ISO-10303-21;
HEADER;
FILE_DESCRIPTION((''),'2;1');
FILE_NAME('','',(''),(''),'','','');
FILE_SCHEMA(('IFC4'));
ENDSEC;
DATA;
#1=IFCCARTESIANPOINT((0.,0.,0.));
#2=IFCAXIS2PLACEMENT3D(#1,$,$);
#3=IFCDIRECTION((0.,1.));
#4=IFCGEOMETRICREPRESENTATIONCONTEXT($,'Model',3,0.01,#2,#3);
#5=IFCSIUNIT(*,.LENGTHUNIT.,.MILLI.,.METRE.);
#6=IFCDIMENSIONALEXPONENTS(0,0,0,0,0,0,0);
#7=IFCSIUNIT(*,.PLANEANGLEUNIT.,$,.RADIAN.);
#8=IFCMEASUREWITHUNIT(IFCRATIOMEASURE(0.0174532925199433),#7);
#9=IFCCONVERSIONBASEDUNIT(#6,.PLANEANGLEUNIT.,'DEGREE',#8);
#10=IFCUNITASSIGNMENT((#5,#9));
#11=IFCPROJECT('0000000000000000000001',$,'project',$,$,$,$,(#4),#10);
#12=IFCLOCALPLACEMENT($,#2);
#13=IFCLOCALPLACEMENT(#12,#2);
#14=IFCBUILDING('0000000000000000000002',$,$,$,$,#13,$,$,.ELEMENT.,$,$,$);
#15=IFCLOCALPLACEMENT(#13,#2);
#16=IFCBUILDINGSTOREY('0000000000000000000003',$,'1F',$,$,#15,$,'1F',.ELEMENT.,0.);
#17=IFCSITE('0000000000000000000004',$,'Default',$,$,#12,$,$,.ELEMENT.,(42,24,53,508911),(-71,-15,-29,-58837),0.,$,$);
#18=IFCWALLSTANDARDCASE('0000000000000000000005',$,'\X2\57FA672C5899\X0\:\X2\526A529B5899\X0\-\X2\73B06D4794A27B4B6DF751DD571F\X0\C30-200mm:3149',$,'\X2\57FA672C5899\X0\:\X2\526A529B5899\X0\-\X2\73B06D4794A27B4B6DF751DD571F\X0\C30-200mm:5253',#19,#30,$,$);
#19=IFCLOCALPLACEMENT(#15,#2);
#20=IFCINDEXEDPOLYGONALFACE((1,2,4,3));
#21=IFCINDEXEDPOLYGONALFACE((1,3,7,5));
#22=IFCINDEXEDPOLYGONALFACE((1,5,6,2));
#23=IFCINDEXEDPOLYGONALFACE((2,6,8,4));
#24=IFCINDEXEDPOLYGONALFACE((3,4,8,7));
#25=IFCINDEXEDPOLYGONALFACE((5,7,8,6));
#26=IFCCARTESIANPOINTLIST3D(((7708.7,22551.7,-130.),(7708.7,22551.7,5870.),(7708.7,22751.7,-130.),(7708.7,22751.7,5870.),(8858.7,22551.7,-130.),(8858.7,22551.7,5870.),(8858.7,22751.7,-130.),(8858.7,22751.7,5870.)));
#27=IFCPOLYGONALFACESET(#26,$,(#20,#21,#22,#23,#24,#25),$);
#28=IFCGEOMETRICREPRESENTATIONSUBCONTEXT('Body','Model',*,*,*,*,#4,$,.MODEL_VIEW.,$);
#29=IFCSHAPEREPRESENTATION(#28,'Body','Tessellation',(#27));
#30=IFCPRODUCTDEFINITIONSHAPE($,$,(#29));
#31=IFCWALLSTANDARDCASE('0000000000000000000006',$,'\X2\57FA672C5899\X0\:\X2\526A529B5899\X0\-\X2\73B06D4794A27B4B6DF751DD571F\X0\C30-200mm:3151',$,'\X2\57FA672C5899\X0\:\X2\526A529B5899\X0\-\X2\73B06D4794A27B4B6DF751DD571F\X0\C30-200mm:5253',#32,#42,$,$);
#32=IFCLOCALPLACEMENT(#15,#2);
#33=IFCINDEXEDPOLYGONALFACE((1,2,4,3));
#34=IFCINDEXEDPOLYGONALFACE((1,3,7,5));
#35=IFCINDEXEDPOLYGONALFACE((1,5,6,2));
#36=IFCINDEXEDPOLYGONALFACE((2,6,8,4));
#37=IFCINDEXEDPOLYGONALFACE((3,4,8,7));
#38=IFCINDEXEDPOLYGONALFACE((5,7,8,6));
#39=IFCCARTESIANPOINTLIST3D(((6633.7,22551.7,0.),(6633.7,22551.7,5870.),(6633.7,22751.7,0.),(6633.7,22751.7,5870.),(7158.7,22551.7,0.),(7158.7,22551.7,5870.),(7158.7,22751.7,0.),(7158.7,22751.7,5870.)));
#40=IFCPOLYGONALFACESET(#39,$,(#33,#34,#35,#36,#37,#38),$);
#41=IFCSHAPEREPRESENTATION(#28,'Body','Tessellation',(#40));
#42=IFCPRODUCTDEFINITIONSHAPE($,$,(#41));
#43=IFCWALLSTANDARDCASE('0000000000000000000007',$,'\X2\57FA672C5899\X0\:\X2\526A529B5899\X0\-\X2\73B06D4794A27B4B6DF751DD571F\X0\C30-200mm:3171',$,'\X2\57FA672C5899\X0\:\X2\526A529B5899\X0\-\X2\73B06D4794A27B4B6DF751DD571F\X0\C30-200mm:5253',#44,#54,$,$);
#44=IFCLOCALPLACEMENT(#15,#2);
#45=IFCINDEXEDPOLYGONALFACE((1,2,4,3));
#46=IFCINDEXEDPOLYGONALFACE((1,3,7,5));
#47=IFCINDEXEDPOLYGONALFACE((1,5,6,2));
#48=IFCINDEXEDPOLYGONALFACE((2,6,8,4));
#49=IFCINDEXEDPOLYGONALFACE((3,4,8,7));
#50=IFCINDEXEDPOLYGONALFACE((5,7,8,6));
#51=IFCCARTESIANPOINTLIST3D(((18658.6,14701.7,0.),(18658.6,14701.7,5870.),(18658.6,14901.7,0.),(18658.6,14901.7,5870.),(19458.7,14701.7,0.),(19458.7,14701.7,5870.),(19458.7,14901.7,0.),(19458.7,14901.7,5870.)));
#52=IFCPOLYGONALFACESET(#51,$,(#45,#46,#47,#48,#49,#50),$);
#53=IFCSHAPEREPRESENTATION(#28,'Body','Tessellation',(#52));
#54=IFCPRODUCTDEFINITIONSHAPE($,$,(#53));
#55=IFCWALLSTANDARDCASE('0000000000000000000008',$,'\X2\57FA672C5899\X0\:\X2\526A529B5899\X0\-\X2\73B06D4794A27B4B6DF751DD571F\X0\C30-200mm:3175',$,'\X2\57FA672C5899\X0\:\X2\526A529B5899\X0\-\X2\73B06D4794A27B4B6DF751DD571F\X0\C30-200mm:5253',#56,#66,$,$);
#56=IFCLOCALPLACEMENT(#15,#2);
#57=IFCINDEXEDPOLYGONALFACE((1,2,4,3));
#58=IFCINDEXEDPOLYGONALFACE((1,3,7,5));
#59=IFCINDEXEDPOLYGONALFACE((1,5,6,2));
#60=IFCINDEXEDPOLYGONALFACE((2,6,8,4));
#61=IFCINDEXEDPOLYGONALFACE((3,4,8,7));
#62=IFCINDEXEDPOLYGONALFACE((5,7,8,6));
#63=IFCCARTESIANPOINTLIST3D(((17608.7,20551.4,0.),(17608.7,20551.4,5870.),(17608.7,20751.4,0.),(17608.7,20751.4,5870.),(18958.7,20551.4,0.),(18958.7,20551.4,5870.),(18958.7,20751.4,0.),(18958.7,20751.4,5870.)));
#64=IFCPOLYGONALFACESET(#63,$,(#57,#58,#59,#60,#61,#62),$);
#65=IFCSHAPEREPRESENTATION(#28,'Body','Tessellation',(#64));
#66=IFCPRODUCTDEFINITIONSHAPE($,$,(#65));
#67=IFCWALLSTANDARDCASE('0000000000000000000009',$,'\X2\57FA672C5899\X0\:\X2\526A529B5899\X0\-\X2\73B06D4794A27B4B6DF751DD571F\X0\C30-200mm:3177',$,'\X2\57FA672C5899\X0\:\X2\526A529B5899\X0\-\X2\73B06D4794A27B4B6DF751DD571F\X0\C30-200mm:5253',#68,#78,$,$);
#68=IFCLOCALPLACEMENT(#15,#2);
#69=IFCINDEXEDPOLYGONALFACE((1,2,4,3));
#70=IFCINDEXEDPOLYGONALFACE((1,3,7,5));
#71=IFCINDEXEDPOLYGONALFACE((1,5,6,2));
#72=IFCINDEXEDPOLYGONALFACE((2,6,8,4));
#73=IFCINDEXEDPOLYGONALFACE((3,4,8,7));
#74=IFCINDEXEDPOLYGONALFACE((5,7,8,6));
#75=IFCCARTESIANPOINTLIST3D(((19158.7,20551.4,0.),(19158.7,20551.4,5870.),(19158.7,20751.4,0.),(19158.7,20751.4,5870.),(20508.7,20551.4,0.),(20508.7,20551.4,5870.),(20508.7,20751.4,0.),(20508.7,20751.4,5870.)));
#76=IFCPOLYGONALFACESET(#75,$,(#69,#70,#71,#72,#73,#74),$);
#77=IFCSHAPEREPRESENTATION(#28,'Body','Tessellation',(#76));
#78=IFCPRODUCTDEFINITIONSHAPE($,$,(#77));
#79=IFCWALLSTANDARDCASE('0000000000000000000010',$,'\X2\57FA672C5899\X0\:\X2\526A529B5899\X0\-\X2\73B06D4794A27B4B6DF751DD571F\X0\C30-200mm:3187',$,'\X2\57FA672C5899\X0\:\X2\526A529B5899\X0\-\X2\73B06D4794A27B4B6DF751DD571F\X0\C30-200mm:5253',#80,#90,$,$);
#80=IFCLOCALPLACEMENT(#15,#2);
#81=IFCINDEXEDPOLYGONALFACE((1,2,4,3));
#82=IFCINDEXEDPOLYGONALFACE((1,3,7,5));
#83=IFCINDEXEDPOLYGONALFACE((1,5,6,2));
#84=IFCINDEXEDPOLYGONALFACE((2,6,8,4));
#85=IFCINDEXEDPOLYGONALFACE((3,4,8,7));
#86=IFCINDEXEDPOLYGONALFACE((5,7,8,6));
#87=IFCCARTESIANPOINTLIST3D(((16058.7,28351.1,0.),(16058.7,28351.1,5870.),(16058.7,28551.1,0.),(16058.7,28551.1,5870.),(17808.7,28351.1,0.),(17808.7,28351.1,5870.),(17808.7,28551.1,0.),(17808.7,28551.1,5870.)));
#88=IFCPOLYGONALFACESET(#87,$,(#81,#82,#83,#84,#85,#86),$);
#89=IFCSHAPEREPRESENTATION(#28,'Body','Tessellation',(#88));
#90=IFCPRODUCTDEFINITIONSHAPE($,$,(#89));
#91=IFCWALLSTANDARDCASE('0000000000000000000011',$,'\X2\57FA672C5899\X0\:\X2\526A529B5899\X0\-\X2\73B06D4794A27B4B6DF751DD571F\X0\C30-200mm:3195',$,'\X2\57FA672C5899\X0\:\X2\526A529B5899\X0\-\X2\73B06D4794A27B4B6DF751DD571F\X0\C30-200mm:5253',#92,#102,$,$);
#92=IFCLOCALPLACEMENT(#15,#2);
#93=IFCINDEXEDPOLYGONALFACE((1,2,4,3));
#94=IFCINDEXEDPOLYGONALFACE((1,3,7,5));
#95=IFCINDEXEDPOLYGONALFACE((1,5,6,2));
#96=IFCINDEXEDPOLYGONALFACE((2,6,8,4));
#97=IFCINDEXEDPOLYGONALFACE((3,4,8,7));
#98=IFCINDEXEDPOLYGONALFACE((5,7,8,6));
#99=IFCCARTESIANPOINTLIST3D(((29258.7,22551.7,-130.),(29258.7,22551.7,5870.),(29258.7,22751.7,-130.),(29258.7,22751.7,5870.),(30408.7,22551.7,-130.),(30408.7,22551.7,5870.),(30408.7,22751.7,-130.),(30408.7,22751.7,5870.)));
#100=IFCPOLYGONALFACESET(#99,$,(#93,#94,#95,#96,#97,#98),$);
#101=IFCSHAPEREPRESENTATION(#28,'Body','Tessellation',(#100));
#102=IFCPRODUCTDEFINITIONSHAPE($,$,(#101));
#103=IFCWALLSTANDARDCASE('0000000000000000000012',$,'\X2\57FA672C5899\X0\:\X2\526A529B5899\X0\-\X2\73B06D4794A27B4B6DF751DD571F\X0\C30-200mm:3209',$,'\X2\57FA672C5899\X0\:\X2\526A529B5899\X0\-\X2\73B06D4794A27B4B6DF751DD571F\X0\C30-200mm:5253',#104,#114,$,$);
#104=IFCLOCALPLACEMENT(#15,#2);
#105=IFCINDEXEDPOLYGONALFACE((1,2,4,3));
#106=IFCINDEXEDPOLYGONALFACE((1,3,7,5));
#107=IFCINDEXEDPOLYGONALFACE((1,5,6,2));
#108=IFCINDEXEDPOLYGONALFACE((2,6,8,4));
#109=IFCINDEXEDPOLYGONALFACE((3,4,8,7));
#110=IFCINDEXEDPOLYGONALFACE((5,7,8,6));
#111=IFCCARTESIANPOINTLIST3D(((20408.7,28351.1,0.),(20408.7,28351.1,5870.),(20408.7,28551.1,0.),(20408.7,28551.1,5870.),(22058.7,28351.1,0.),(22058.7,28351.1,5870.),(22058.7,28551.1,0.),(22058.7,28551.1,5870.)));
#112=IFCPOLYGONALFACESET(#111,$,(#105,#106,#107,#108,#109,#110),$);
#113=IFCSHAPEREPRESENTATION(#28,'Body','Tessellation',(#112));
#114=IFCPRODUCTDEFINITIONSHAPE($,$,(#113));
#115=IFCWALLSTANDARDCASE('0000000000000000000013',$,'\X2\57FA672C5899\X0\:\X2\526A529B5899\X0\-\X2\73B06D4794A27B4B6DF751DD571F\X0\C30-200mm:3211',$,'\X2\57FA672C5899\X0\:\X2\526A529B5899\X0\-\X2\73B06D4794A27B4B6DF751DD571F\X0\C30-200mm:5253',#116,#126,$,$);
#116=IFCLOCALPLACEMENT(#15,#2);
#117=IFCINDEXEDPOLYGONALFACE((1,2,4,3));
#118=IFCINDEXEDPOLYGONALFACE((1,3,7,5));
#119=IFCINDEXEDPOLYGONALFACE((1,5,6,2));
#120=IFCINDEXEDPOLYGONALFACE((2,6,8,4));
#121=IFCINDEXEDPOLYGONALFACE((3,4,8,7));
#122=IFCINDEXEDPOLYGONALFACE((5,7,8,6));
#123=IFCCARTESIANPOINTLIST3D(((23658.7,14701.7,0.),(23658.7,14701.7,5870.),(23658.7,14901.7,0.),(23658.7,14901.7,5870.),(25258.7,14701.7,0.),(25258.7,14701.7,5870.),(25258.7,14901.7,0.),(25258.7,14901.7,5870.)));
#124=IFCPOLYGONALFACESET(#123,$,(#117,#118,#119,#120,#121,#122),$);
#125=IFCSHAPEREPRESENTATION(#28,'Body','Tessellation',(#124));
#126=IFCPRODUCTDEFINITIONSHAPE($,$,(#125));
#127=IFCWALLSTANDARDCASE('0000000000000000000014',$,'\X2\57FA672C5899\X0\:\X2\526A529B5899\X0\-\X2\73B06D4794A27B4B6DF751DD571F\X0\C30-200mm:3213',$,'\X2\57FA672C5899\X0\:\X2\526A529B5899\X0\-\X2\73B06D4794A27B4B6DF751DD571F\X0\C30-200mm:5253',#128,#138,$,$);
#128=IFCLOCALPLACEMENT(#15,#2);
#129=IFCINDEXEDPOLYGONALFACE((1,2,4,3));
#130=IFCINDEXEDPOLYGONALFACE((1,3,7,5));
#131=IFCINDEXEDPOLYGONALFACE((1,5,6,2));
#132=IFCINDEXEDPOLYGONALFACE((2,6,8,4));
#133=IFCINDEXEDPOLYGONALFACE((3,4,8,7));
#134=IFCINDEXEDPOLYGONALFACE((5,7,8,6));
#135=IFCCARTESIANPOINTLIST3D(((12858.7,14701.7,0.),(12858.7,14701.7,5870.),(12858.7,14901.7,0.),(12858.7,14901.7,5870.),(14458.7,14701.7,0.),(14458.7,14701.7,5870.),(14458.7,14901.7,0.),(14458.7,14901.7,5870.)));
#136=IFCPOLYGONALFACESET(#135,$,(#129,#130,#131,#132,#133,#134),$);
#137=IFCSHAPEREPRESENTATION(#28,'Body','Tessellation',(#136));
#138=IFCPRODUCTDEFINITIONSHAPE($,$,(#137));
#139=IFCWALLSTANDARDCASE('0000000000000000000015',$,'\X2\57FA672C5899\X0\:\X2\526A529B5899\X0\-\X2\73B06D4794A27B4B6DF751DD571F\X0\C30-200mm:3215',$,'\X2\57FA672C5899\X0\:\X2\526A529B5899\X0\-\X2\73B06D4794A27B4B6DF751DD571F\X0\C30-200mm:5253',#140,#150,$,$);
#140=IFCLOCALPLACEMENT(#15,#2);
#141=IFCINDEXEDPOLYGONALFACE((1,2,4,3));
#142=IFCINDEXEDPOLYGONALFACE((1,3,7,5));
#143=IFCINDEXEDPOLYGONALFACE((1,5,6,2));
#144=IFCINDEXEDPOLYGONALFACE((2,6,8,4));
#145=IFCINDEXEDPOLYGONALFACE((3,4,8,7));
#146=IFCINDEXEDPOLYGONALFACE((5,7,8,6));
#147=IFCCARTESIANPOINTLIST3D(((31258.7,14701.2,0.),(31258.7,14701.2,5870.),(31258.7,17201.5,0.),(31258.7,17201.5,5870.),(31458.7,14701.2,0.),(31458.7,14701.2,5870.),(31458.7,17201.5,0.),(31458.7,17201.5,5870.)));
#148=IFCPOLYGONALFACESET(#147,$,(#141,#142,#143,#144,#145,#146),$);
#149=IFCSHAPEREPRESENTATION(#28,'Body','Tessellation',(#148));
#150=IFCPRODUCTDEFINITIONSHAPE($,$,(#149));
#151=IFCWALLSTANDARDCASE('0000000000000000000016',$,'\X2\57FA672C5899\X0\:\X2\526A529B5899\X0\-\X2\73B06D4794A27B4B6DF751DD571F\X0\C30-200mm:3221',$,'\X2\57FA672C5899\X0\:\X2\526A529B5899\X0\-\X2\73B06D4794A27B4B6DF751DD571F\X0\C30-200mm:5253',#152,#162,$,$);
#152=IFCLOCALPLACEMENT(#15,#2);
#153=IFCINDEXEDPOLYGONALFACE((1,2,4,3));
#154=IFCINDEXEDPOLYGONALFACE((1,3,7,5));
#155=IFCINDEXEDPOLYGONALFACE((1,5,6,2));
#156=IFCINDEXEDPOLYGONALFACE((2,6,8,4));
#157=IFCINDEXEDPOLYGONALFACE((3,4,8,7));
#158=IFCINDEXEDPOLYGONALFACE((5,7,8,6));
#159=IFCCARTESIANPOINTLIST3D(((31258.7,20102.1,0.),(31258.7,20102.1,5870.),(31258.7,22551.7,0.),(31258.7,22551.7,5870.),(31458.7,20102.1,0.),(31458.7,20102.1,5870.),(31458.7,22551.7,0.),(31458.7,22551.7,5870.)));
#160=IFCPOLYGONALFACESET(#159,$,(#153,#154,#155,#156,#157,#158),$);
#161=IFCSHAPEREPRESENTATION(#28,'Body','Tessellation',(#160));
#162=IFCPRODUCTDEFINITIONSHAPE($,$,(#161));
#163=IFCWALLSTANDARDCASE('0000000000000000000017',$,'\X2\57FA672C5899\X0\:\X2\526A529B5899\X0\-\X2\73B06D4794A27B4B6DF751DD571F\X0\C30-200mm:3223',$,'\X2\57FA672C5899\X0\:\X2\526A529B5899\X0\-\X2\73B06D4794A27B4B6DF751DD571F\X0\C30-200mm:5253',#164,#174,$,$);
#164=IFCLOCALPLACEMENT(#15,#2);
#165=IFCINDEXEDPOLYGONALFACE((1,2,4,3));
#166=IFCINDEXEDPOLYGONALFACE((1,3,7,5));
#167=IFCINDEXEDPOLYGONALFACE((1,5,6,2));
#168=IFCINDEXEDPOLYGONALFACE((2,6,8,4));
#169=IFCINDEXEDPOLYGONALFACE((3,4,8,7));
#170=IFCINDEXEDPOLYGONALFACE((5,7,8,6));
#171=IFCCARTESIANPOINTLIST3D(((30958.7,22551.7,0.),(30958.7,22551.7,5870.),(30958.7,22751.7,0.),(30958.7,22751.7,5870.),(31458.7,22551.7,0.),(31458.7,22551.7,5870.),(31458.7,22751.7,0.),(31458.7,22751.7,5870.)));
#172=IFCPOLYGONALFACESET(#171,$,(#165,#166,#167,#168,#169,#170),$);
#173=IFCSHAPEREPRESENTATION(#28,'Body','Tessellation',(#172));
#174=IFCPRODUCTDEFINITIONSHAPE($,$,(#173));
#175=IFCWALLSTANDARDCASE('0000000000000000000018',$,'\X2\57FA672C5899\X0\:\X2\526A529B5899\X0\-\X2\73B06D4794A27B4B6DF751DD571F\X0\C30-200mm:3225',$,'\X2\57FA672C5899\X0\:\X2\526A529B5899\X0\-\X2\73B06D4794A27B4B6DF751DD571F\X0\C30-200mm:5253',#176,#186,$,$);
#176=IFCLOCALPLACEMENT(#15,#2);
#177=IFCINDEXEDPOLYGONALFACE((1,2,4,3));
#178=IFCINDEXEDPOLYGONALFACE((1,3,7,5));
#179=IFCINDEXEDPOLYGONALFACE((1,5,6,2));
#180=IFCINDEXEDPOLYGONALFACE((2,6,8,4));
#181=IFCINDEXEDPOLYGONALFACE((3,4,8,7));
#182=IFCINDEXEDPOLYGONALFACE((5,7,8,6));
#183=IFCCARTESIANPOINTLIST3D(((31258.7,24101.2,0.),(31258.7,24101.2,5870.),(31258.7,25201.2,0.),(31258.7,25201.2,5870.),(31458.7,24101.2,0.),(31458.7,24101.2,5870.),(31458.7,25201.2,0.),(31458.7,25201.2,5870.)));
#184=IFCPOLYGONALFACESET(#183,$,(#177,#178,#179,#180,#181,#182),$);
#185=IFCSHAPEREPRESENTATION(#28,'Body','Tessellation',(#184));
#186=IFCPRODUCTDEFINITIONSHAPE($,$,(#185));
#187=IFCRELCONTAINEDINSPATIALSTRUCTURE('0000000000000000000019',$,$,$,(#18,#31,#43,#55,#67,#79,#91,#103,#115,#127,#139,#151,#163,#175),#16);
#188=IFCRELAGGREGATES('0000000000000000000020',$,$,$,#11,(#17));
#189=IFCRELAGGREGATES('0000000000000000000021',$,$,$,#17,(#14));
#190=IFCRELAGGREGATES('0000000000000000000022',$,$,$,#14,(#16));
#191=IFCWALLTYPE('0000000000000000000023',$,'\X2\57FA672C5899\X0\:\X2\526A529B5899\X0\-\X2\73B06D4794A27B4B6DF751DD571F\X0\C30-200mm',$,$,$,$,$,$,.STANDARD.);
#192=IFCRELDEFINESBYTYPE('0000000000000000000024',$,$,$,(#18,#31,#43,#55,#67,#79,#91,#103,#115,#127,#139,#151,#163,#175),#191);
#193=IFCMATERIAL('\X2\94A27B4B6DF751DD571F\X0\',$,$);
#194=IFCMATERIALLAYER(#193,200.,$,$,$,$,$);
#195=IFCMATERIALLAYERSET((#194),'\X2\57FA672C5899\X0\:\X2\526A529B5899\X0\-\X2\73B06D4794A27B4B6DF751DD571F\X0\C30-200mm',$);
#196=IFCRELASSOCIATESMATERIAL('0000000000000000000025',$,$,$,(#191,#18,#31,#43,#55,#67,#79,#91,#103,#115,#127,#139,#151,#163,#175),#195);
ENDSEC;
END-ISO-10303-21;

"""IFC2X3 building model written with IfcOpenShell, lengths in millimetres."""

from ifc_helpers import new_model, entity, si_unit, converted_unit, direction, frame, frame_2d, origin, place, context, subcontext, project, spatial, rectangle, extrude, material, layer, layer_set, layer_usage, type_object, element, save


model = new_model("IFC2X3")

# Units and contexts
model_context = context("Model", 3, precision=0.01, world=origin(), true_north=direction((0.0, 1.0)))
body_context = subcontext(model_context, "Body", "Model", "MODEL_VIEW")
ifc_project = project(units=[si_unit("LENGTHUNIT", "METRE", prefix="MILLI"), converted_unit("PLANEANGLEUNIT", "DEGREE", entity("IfcRatioMeasure", 0.0174532925199433), si_unit("PLANEANGLEUNIT", "RADIAN"), dimensions=[0, 0, 0, 0, 0, 0, 0])], contexts=[model_context])

# Site, building, storey
site_placement = place(None, origin())
site = spatial("IfcSite", under=ifc_project, at=site_placement, Name="Default", CompositionType="ELEMENT", RefLatitude=(42, 24, 53, 508911), RefLongitude=(-71, -15, -29, -58837), RefElevation=0.0)
building_placement = place(site_placement, origin())
building = spatial("IfcBuilding", under=site, at=building_placement, CompositionType="ELEMENT")
storey_placement = place(building_placement, origin())
storey = spatial("IfcBuildingStorey", under=building, at=storey_placement, Name="1F", LongName="1F", CompositionType="ELEMENT", Elevation=0.0)

# Walls
ifc_material = material(Name="钢筋混凝土")
ifc_layer_1 = layer(ifc_material, 200.0)
ifc_layer_set_1 = layer_set([ifc_layer_1], Name="基本墙:剪力墙-现浇钢筋混凝土C30-200mm")
ifc_layer_usage_1 = layer_usage(ifc_layer_set_1, "AXIS2", "NEGATIVE", 100.0)
wall_type_1 = type_object("IfcWallType", Name="基本墙:剪力墙-现浇钢筋混凝土C30-200mm", PredefinedType="STANDARD", material=ifc_layer_set_1)
wall_1_placement = place(storey_placement, frame((7708.7, 22651.7, -130.0)))
element("IfcWallStandardCase", 1, at=wall_1_placement, inside=storey, type_object=wall_type_1, material=ifc_layer_usage_1, Name="基本墙:剪力墙-现浇钢筋混凝土C30-200mm:3149", ObjectType="基本墙:剪力墙-现浇钢筋混凝土C30-200mm:5253", context=body_context, shape_type="SweptSolid", body=[
    extrude(rectangle(XDim=1150.0, YDim=200.0, at=frame_2d((575.0, 0.0), x_axis=(-1.0, 0.0))), origin(), (0.0, 0.0, 1.0), 6000.0),
])
ifc_layer_usage_2 = layer_usage(ifc_layer_set_1, "AXIS2", "NEGATIVE", 100.0)
wall_2_placement = place(storey_placement, frame((7158.7, 22651.7, 0.0), z_axis=(0.0, 0.0, 1.0), x_axis=(-1.0, 0.0, 0.0)))
element("IfcWallStandardCase", 2, at=wall_2_placement, inside=storey, type_object=wall_type_1, material=ifc_layer_usage_2, Name="基本墙:剪力墙-现浇钢筋混凝土C30-200mm:3151", ObjectType="基本墙:剪力墙-现浇钢筋混凝土C30-200mm:5253", context=body_context, shape_type="SweptSolid", body=[
    extrude(rectangle(XDim=525.0, YDim=200.0, at=frame_2d((262.5, 0.0), x_axis=(-1.0, 0.0))), origin(), (0.0, 0.0, 1.0), 5870.0),
])
ifc_layer_usage_3 = layer_usage(ifc_layer_set_1, "AXIS2", "NEGATIVE", 100.0)
wall_3_placement = place(storey_placement, frame((18658.6, 14801.7, 0.0)))
element("IfcWallStandardCase", 3, at=wall_3_placement, inside=storey, type_object=wall_type_1, material=ifc_layer_usage_3, Name="基本墙:剪力墙-现浇钢筋混凝土C30-200mm:3171", ObjectType="基本墙:剪力墙-现浇钢筋混凝土C30-200mm:5253", context=body_context, shape_type="SweptSolid", body=[
    extrude(rectangle(XDim=800.0, YDim=200.0, at=frame_2d((400.0, 0.0), x_axis=(-1.0, 0.0))), origin(), (0.0, 0.0, 1.0), 5870.0),
])
ifc_layer_usage_4 = layer_usage(ifc_layer_set_1, "AXIS2", "NEGATIVE", 100.0)
wall_4_placement = place(storey_placement, frame((18958.7, 20651.4, 0.0), z_axis=(0.0, 0.0, 1.0), x_axis=(-1.0, 0.0, 0.0)))
element("IfcWallStandardCase", 4, at=wall_4_placement, inside=storey, type_object=wall_type_1, material=ifc_layer_usage_4, Name="基本墙:剪力墙-现浇钢筋混凝土C30-200mm:3175", ObjectType="基本墙:剪力墙-现浇钢筋混凝土C30-200mm:5253", context=body_context, shape_type="SweptSolid", body=[
    extrude(rectangle(XDim=1350.0, YDim=200.0, at=frame_2d((675.0, 0.0), x_axis=(-1.0, 0.0))), origin(), (0.0, 0.0, 1.0), 5870.0),
])
ifc_layer_usage_5 = layer_usage(ifc_layer_set_1, "AXIS2", "NEGATIVE", 100.0)
wall_5_placement = place(storey_placement, frame((19158.7, 20651.4, 0.0)))
element("IfcWallStandardCase", 5, at=wall_5_placement, inside=storey, type_object=wall_type_1, material=ifc_layer_usage_5, Name="基本墙:剪力墙-现浇钢筋混凝土C30-200mm:3177", ObjectType="基本墙:剪力墙-现浇钢筋混凝土C30-200mm:5253", context=body_context, shape_type="SweptSolid", body=[
    extrude(rectangle(XDim=1350.0, YDim=200.0, at=frame_2d((675.0, 0.0), x_axis=(-1.0, 0.0))), origin(), (0.0, 0.0, 1.0), 5870.0),
])
ifc_layer_usage_6 = layer_usage(ifc_layer_set_1, "AXIS2", "NEGATIVE", 100.0)
wall_6_placement = place(storey_placement, frame((16058.7, 28451.1, 0.0)))
element("IfcWallStandardCase", 6, at=wall_6_placement, inside=storey, type_object=wall_type_1, material=ifc_layer_usage_6, Name="基本墙:剪力墙-现浇钢筋混凝土C30-200mm:3187", ObjectType="基本墙:剪力墙-现浇钢筋混凝土C30-200mm:5253", context=body_context, shape_type="SweptSolid", body=[
    extrude(rectangle(XDim=1750.0, YDim=200.0, at=frame_2d((875.0, 0.0), x_axis=(-1.0, 0.0))), origin(), (0.0, 0.0, 1.0), 5870.0),
])
ifc_layer_usage_7 = layer_usage(ifc_layer_set_1, "AXIS2", "POSITIVE", -100.0)
wall_7_placement = place(storey_placement, frame((30408.7, 22651.7, -130.0), z_axis=(0.0, 0.0, 1.0), x_axis=(-1.0, 0.0, 0.0)))
element("IfcWallStandardCase", 7, at=wall_7_placement, inside=storey, type_object=wall_type_1, material=ifc_layer_usage_7, Name="基本墙:剪力墙-现浇钢筋混凝土C30-200mm:3195", ObjectType="基本墙:剪力墙-现浇钢筋混凝土C30-200mm:5253", context=body_context, shape_type="SweptSolid", body=[
    extrude(rectangle(XDim=1150.0, YDim=200.0, at=frame_2d((575.0, 0.0), x_axis=(-1.0, 0.0))), origin(), (0.0, 0.0, 1.0), 6000.0),
])
ifc_layer_usage_8 = layer_usage(ifc_layer_set_1, "AXIS2", "POSITIVE", -100.0)
wall_8_placement = place(storey_placement, frame((22058.7, 28451.1, 0.0), z_axis=(0.0, 0.0, 1.0), x_axis=(-1.0, 0.0, 0.0)))
element("IfcWallStandardCase", 8, at=wall_8_placement, inside=storey, type_object=wall_type_1, material=ifc_layer_usage_8, Name="基本墙:剪力墙-现浇钢筋混凝土C30-200mm:3209", ObjectType="基本墙:剪力墙-现浇钢筋混凝土C30-200mm:5253", context=body_context, shape_type="SweptSolid", body=[
    extrude(rectangle(XDim=1650.0, YDim=200.0, at=frame_2d((825.0, 0.0), x_axis=(-1.0, 0.0))), origin(), (0.0, 0.0, 1.0), 5870.0),
])
ifc_layer_usage_9 = layer_usage(ifc_layer_set_1, "AXIS2", "NEGATIVE", 100.0)
wall_9_placement = place(storey_placement, frame((23658.7, 14801.7, 0.0)))
element("IfcWallStandardCase", 9, at=wall_9_placement, inside=storey, type_object=wall_type_1, material=ifc_layer_usage_9, Name="基本墙:剪力墙-现浇钢筋混凝土C30-200mm:3211", ObjectType="基本墙:剪力墙-现浇钢筋混凝土C30-200mm:5253", context=body_context, shape_type="SweptSolid", body=[
    extrude(rectangle(XDim=1600.0, YDim=200.0, at=frame_2d((800.0, 0.0), x_axis=(-1.0, 0.0))), origin(), (0.0, 0.0, 1.0), 5870.0),
])
ifc_layer_usage_10 = layer_usage(ifc_layer_set_1, "AXIS2", "POSITIVE", -100.0)
wall_10_placement = place(storey_placement, frame((14458.7, 14801.7, 0.0), z_axis=(0.0, 0.0, 1.0), x_axis=(-1.0, 0.0, 0.0)))
element("IfcWallStandardCase", 10, at=wall_10_placement, inside=storey, type_object=wall_type_1, material=ifc_layer_usage_10, Name="基本墙:剪力墙-现浇钢筋混凝土C30-200mm:3213", ObjectType="基本墙:剪力墙-现浇钢筋混凝土C30-200mm:5253", context=body_context, shape_type="SweptSolid", body=[
    extrude(rectangle(XDim=1600.0, YDim=200.0, at=frame_2d((800.0, 0.0), x_axis=(-1.0, 0.0))), origin(), (0.0, 0.0, 1.0), 5870.0),
])
ifc_layer_usage_11 = layer_usage(ifc_layer_set_1, "AXIS2", "NEGATIVE", 100.0)
wall_11_placement = place(storey_placement, frame((31358.7, 14701.2, 0.0), z_axis=(0.0, 0.0, 1.0), x_axis=(0.0, 1.0, 0.0)))
element("IfcWallStandardCase", 11, at=wall_11_placement, inside=storey, type_object=wall_type_1, material=ifc_layer_usage_11, Name="基本墙:剪力墙-现浇钢筋混凝土C30-200mm:3215", ObjectType="基本墙:剪力墙-现浇钢筋混凝土C30-200mm:5253", context=body_context, shape_type="SweptSolid", body=[
    extrude(rectangle(XDim=2500.2, YDim=200.0, at=frame_2d((1250.1, 0.0), x_axis=(-1.0, 0.0))), origin(), (0.0, 0.0, 1.0), 5870.0),
])
ifc_layer_usage_12 = layer_usage(ifc_layer_set_1, "AXIS2", "NEGATIVE", 100.0)
wall_12_placement = place(storey_placement, frame((31358.7, 20102.1, 0.0), z_axis=(0.0, 0.0, 1.0), x_axis=(0.0, 1.0, 0.0)))
element("IfcWallStandardCase", 12, at=wall_12_placement, inside=storey, type_object=wall_type_1, material=ifc_layer_usage_12, Name="基本墙:剪力墙-现浇钢筋混凝土C30-200mm:3221", ObjectType="基本墙:剪力墙-现浇钢筋混凝土C30-200mm:5253", context=body_context, shape_type="SweptSolid", body=[
    extrude(rectangle(XDim=2449.6, YDim=200.0, at=frame_2d((1224.8, 0.0), x_axis=(-1.0, 0.0))), origin(), (0.0, 0.0, 1.0), 5870.0),
])
ifc_layer_usage_13 = layer_usage(ifc_layer_set_1, "AXIS2", "NEGATIVE", 100.0)
wall_13_placement = place(storey_placement, frame((31458.7, 22651.7, 0.0), z_axis=(0.0, 0.0, 1.0), x_axis=(-1.0, 0.0, 0.0)))
element("IfcWallStandardCase", 13, at=wall_13_placement, inside=storey, type_object=wall_type_1, material=ifc_layer_usage_13, Name="基本墙:剪力墙-现浇钢筋混凝土C30-200mm:3223", ObjectType="基本墙:剪力墙-现浇钢筋混凝土C30-200mm:5253", context=body_context, shape_type="SweptSolid", body=[
    extrude(rectangle(XDim=500.0, YDim=200.0, at=frame_2d((250.0, 0.0), x_axis=(-1.0, 0.0))), origin(), (0.0, 0.0, 1.0), 5870.0),
])
ifc_layer_usage_14 = layer_usage(ifc_layer_set_1, "AXIS2", "NEGATIVE", 100.0)
wall_14_placement = place(storey_placement, frame((31358.7, 24101.2, 0.0), z_axis=(0.0, 0.0, 1.0), x_axis=(0.0, 1.0, 0.0)))
element("IfcWallStandardCase", 14, at=wall_14_placement, inside=storey, type_object=wall_type_1, material=ifc_layer_usage_14, Name="基本墙:剪力墙-现浇钢筋混凝土C30-200mm:3225", ObjectType="基本墙:剪力墙-现浇钢筋混凝土C30-200mm:5253", context=body_context, shape_type="SweptSolid", body=[
    extrude(rectangle(XDim=1100.0, YDim=200.0, at=frame_2d((550.0, 0.0), x_axis=(-1.0, 0.0))), origin(), (0.0, 0.0, 1.0), 5870.0),
])

save(model, "model.ifc")
